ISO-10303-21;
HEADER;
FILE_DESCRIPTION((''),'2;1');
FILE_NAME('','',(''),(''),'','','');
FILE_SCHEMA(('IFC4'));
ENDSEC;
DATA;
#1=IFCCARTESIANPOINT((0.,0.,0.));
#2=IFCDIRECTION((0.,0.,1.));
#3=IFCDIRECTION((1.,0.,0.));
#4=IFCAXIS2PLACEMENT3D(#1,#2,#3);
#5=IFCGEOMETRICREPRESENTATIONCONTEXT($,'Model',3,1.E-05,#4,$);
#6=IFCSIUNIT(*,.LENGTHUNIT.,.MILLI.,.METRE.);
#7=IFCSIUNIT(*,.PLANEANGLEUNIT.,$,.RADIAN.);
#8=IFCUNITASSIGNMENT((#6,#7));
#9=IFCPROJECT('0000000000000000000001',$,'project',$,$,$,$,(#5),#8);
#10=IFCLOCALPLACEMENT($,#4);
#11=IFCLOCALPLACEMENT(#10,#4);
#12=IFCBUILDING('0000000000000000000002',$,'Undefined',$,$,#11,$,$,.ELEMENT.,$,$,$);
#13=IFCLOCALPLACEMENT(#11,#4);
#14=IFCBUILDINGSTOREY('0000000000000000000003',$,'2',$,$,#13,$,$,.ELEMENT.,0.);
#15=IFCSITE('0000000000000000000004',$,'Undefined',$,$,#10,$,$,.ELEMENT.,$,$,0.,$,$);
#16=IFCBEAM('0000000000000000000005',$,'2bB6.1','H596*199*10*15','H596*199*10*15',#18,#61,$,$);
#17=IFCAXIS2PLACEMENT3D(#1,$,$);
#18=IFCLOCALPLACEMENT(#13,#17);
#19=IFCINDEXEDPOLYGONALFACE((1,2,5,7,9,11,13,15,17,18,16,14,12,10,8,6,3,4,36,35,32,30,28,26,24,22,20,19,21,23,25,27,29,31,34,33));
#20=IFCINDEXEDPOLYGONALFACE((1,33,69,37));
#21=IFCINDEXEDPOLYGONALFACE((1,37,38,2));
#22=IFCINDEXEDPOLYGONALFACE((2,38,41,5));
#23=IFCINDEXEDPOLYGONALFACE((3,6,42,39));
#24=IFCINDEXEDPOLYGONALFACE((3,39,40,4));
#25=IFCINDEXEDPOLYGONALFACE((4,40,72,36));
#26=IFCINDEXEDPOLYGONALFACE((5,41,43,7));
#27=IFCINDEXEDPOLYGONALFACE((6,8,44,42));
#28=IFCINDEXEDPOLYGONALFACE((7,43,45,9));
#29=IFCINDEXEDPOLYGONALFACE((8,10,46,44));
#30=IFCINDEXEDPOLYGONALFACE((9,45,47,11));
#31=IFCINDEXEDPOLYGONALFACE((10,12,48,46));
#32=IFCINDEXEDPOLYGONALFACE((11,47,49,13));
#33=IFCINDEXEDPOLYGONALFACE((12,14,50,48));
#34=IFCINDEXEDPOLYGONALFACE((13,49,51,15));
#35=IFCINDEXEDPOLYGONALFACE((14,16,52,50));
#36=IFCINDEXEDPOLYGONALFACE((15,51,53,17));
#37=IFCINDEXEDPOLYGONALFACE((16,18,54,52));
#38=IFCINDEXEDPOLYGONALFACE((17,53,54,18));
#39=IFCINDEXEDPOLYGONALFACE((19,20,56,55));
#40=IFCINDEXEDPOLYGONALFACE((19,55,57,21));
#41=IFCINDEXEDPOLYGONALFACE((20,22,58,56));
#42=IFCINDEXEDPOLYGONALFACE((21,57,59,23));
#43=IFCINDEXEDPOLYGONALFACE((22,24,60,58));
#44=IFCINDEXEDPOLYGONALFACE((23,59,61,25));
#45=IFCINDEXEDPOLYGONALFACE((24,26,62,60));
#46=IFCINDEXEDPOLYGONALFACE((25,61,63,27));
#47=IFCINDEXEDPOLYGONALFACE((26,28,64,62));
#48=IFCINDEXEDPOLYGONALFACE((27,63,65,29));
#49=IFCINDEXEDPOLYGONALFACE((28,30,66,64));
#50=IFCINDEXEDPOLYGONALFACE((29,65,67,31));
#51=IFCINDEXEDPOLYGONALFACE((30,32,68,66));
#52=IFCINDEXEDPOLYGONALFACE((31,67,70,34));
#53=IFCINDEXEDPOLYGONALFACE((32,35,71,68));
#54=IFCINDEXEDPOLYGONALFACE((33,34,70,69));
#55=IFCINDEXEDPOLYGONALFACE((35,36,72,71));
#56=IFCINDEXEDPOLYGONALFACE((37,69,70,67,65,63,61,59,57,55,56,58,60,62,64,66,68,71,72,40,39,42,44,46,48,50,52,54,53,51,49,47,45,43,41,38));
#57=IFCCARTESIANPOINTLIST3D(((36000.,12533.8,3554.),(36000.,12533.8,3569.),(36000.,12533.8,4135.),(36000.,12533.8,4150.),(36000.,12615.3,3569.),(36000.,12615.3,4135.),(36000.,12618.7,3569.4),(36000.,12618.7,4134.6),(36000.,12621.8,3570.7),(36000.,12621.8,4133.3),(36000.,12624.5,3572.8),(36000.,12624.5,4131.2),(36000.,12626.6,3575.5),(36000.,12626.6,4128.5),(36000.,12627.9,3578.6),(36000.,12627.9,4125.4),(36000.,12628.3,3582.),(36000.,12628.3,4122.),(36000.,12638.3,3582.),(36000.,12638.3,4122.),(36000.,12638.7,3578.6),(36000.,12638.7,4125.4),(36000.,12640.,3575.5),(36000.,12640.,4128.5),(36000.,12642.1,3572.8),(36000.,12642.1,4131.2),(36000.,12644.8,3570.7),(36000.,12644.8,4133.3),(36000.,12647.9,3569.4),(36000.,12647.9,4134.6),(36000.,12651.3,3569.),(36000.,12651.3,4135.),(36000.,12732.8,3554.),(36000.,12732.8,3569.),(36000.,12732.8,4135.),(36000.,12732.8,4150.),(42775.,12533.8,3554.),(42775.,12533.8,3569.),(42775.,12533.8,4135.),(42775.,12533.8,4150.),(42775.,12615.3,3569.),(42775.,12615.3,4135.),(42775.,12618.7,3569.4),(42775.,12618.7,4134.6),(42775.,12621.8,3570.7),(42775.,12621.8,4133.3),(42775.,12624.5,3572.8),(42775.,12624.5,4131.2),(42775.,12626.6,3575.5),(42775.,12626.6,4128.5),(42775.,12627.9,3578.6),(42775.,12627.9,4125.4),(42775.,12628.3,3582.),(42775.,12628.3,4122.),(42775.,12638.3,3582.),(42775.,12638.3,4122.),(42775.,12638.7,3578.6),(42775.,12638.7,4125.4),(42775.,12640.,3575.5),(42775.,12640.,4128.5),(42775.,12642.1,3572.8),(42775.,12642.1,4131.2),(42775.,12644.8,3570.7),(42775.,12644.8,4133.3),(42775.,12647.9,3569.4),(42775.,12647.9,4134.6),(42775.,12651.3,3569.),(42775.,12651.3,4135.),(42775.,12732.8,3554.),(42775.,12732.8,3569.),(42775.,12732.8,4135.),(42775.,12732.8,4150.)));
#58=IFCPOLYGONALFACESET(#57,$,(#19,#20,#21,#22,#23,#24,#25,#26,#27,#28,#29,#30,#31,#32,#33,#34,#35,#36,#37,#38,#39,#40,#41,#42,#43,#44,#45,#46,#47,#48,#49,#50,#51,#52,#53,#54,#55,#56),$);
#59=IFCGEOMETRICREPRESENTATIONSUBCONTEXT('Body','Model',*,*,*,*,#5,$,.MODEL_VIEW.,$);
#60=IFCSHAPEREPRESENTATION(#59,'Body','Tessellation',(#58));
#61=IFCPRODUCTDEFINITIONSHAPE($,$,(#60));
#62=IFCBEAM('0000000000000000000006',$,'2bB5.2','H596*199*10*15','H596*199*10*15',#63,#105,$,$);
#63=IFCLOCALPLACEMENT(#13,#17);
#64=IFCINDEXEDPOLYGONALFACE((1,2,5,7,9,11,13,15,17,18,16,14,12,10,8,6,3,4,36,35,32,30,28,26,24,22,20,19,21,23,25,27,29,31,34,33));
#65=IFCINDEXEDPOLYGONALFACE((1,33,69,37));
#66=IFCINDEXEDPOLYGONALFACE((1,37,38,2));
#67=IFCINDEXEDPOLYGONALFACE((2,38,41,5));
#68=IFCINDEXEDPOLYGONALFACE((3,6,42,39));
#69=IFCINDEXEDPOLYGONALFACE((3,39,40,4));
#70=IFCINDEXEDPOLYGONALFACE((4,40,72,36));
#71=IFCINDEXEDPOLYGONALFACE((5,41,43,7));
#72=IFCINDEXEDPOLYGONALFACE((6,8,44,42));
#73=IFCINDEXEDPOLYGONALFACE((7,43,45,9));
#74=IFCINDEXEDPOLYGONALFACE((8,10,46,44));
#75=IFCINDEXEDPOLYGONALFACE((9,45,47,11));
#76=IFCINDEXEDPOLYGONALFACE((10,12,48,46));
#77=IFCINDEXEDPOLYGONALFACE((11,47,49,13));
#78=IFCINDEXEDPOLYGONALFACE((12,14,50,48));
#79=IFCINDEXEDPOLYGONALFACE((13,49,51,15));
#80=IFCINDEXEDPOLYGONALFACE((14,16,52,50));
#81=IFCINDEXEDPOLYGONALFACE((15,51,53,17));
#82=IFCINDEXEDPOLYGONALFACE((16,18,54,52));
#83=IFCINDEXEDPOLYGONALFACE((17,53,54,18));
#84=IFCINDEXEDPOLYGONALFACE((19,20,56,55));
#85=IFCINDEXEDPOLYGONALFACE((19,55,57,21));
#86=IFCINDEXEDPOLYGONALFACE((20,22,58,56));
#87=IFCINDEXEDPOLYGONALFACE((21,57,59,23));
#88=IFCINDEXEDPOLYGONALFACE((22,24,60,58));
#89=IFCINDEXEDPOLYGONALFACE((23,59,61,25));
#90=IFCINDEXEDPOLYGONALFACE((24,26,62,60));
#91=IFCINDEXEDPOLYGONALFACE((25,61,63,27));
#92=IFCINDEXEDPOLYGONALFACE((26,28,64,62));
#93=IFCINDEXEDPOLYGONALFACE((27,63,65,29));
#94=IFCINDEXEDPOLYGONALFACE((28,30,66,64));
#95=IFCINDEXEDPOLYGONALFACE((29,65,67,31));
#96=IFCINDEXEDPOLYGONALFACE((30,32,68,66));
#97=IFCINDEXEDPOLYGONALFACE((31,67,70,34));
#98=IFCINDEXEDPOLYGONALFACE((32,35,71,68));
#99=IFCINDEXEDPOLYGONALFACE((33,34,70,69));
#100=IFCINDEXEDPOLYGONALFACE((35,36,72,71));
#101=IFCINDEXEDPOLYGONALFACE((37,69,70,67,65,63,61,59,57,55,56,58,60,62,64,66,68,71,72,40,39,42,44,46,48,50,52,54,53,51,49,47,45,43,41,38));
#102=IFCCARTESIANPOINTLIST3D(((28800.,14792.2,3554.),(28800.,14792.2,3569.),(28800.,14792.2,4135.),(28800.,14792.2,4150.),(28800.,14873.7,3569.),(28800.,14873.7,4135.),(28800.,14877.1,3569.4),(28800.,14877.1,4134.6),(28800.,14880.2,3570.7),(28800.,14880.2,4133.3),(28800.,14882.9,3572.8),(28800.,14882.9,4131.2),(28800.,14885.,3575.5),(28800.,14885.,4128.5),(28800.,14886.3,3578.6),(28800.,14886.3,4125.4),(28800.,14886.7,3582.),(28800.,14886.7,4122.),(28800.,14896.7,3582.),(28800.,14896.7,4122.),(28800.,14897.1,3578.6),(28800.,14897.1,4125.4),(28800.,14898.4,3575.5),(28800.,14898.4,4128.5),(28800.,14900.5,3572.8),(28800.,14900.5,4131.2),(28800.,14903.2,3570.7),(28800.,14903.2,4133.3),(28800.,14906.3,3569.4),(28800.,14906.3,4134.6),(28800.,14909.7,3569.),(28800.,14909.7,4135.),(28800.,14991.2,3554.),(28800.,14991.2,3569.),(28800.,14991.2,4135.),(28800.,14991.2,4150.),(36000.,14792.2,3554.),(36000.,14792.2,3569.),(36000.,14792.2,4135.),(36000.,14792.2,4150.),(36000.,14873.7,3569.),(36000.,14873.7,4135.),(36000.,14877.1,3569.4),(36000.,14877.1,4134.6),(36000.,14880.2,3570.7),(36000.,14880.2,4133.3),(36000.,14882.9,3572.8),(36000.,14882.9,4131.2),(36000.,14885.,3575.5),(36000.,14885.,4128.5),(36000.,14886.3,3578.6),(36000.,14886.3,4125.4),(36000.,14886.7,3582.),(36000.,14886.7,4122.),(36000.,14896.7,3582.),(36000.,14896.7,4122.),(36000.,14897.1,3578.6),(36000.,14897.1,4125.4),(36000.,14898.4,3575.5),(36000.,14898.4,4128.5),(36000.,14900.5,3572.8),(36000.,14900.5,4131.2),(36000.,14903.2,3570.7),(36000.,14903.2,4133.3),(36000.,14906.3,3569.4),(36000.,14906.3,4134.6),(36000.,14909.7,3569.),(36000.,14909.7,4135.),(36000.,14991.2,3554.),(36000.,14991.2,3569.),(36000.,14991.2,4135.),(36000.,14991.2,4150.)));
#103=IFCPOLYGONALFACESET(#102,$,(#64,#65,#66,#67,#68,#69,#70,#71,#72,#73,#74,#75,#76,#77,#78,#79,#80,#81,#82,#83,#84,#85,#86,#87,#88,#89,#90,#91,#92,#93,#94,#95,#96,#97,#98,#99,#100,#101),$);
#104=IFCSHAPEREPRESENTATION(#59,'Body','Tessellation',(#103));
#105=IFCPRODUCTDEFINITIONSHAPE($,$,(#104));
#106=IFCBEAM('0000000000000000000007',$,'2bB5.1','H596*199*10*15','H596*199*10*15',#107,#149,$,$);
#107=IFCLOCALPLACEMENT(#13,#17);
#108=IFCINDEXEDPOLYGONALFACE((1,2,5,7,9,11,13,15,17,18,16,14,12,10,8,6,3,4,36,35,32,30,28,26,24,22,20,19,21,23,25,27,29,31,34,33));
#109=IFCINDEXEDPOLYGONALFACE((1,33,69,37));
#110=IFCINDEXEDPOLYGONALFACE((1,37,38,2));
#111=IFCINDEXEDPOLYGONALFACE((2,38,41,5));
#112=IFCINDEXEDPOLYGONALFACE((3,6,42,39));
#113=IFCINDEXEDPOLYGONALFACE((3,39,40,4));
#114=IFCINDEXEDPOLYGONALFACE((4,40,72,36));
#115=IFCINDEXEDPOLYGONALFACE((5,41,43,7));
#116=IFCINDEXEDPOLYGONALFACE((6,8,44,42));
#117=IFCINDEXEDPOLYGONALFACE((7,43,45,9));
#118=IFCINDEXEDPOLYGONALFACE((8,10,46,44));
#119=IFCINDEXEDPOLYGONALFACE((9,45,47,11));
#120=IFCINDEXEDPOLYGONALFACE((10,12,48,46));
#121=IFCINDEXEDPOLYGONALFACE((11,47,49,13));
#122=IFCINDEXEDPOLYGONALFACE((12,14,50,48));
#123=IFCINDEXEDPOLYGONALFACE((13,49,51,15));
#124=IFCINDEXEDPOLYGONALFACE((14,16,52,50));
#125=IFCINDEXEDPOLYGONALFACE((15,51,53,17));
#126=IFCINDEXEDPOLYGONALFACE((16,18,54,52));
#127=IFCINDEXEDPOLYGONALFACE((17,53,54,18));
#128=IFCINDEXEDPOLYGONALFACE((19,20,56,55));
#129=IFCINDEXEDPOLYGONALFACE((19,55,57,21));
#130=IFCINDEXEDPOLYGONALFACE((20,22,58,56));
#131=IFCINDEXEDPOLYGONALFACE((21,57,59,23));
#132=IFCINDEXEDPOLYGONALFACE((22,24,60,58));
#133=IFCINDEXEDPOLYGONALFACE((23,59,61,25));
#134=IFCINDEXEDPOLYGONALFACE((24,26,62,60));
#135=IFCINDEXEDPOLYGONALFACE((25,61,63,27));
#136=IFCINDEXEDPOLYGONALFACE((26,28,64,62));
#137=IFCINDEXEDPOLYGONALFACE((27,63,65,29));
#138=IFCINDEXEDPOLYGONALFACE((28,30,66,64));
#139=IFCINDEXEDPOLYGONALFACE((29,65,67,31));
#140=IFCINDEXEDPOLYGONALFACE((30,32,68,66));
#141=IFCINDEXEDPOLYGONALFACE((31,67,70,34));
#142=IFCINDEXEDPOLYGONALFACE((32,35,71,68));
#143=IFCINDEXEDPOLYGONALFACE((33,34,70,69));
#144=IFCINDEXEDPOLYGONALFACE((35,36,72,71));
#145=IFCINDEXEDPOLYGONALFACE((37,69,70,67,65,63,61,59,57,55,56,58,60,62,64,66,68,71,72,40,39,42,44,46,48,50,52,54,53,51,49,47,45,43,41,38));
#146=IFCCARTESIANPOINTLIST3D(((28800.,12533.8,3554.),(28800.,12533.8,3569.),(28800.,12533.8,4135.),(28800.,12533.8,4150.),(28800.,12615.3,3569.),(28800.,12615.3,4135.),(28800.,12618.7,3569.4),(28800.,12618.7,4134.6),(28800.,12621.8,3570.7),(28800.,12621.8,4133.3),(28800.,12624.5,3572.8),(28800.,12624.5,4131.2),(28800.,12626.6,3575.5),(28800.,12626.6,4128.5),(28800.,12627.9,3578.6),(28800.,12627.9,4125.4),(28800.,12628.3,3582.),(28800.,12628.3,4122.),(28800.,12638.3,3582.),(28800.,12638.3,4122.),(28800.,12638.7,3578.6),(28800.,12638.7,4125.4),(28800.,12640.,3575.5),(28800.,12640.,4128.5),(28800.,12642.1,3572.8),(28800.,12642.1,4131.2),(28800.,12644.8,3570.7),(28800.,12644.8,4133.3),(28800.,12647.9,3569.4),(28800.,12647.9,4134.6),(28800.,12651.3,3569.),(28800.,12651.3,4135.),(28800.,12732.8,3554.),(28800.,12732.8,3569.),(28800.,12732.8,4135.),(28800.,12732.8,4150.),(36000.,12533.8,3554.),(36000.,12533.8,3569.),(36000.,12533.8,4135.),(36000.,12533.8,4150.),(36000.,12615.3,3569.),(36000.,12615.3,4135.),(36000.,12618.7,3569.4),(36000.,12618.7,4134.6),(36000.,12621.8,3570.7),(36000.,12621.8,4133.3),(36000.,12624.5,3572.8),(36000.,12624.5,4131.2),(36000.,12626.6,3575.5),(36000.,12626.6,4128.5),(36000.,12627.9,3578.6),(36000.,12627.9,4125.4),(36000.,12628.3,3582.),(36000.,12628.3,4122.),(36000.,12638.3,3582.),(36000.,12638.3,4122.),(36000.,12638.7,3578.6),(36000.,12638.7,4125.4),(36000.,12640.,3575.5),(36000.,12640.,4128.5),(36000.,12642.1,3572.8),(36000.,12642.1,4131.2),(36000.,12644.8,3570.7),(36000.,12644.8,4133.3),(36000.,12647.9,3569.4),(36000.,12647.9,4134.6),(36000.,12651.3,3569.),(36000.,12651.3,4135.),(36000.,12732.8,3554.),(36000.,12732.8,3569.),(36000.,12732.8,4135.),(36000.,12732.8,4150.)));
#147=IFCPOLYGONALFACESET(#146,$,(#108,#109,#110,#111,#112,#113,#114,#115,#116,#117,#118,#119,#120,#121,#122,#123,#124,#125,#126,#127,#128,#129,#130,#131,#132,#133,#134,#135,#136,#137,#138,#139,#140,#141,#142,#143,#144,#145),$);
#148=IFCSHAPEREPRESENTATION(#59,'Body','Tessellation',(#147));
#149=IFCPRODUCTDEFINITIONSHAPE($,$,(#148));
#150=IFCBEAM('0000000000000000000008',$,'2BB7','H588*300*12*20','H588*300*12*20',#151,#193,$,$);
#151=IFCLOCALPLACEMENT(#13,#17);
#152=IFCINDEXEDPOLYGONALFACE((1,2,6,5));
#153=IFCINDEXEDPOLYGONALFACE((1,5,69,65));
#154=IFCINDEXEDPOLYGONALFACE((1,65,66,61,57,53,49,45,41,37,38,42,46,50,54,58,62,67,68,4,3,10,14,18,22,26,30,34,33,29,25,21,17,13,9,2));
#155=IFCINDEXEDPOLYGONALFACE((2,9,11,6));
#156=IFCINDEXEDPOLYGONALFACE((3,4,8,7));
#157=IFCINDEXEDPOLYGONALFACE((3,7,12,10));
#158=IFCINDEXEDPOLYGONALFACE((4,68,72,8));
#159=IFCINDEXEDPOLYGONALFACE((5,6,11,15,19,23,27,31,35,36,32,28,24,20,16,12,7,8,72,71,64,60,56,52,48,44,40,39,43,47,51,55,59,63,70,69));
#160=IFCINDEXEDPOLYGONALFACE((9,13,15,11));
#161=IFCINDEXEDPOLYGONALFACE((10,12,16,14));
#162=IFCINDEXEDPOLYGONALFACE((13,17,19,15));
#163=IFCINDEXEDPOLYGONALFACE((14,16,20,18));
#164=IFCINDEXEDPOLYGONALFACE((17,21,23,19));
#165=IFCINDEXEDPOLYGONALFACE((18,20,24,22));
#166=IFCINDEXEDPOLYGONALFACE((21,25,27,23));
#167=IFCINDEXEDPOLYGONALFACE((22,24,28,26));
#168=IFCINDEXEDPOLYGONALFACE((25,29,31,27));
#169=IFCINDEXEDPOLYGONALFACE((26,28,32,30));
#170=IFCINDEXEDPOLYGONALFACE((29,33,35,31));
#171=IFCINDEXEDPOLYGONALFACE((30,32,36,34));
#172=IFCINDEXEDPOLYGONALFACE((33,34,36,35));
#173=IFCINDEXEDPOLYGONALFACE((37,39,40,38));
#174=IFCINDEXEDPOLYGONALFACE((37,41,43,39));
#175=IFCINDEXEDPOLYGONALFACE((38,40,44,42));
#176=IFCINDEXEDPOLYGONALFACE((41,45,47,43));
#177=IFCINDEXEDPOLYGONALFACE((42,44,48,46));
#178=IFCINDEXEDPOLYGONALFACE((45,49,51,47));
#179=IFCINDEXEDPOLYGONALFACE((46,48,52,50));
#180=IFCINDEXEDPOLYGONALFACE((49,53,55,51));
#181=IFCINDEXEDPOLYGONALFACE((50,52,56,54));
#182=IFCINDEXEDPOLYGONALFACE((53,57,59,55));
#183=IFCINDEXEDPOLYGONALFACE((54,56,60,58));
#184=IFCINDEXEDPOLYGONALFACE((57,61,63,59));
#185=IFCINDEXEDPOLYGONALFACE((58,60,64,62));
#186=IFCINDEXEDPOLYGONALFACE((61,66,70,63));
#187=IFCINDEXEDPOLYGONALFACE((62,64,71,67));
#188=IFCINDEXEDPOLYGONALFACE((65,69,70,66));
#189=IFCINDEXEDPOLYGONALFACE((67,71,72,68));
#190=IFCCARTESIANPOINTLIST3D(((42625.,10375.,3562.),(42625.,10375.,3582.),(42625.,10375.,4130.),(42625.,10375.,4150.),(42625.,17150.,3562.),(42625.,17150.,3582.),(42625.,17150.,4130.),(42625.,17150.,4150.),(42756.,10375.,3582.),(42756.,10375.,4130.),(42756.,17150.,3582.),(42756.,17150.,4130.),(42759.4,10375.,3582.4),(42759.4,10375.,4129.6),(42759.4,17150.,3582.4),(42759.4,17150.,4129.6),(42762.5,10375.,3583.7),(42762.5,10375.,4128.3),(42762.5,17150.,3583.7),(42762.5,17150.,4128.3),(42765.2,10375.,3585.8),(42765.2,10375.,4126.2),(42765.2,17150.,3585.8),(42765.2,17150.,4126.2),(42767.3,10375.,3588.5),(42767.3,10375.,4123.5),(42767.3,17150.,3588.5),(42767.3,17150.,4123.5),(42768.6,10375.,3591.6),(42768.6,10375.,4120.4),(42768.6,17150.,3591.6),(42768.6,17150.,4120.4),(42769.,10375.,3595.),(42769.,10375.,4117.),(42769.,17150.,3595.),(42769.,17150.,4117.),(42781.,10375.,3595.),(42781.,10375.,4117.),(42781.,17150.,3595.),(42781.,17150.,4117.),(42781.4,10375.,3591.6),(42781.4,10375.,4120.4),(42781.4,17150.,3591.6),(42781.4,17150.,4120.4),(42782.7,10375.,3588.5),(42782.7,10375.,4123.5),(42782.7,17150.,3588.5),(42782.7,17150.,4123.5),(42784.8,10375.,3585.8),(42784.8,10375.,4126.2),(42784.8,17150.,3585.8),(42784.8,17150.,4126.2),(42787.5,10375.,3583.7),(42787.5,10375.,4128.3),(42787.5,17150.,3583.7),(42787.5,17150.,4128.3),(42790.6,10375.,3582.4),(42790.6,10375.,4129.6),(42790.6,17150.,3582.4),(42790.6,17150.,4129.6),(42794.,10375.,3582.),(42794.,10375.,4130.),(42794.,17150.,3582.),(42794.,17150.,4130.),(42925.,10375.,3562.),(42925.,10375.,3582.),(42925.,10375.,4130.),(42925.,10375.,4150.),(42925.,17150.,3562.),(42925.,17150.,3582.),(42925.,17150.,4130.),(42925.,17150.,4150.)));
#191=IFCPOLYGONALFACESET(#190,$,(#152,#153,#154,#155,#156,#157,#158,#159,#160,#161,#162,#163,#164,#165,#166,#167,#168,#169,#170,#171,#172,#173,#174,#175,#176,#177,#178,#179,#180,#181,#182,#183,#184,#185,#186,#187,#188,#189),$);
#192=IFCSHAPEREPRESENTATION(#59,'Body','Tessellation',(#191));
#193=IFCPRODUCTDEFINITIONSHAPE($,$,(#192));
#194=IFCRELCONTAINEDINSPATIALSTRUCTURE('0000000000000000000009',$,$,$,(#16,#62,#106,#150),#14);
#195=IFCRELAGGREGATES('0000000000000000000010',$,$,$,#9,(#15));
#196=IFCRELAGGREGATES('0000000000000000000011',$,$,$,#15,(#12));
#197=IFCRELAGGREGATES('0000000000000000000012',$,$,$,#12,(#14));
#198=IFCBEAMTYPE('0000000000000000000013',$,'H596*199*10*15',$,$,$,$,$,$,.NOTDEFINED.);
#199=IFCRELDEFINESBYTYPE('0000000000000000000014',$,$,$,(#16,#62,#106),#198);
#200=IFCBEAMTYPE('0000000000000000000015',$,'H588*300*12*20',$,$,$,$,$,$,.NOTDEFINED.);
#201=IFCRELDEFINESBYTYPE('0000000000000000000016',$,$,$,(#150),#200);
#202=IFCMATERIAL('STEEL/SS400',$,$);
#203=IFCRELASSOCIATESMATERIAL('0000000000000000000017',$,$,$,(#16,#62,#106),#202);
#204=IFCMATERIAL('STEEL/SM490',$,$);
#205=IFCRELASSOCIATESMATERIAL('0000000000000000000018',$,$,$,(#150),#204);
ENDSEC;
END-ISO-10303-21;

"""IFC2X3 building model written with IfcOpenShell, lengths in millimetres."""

from ifc_helpers import new_model, si_unit, frame, origin_with_axes, origin_2d_with_axis, place, context, subcontext, project, spatial, i_section, extrude, material, type_object, element, save


model = new_model("IFC2X3")

# Units and contexts
model_context = context("Model", 3, precision=1e-05, world=origin_with_axes())
body_context = subcontext(model_context, "Body", "Model", "MODEL_VIEW")
ifc_project = project(units=[si_unit("LENGTHUNIT", "METRE", prefix="MILLI"), si_unit("PLANEANGLEUNIT", "RADIAN")], contexts=[model_context])

# Site, building, storey
site_placement = place(None, origin_with_axes())
site = spatial("IfcSite", under=ifc_project, at=site_placement, Name="Undefined", CompositionType="ELEMENT", RefElevation=0.0)
building_placement = place(site_placement, origin_with_axes())
building = spatial("IfcBuilding", under=site, at=building_placement, Name="Undefined", CompositionType="ELEMENT")
storey_placement = place(building_placement, origin_with_axes())
storey = spatial("IfcBuildingStorey", under=building, at=storey_placement, Name="2", CompositionType="ELEMENT", Elevation=0.0)

# Beams
ifc_material_1 = material(Name="STEEL/SS400")
beam_type_1 = type_object("IfcBeamType", Name="H596*199*10*15", PredefinedType="NOTDEFINED")
for number, where, z_axis, x_axis, name in (
    (1, (36000.0, 12633.3, 3852.0), (0.0, 0.0, 1.0), (1.0, 0.0, 0.0), "2bB6.1"),
):
    element("IfcBeam", number, at=place(storey_placement, frame(where, z_axis=z_axis, x_axis=x_axis)), inside=storey, type_object=beam_type_1, material=ifc_material_1, Name=name, Description="H596*199*10*15", ObjectType="H596*199*10*15", context=body_context, shape_type="SweptSolid", body=[
        extrude(i_section(OverallWidth=199.0, OverallDepth=596.0, WebThickness=10.0, FlangeThickness=15.0, FilletRadius=13.0, at=origin_2d_with_axis()), frame((6775.0, 0.0, 0.0), z_axis=(-1.0, 0.0, 0.0), x_axis=(0.0, -1.0, 0.0)), (0.0, 0.0, 1.0), 6775.0),
    ])
for number, where, z_axis, x_axis, name in (
    (2, (28800.0, 14891.7, 3852.0), (0.0, 0.0, 1.0), (1.0, 0.0, 0.0), "2bB5.2"),
    (3, (28800.0, 12633.3, 3852.0), (0.0, 0.0, 1.0), (1.0, 0.0, 0.0), "2bB5.1"),
):
    element("IfcBeam", number, at=place(storey_placement, frame(where, z_axis=z_axis, x_axis=x_axis)), inside=storey, type_object=beam_type_1, material=ifc_material_1, Name=name, Description="H596*199*10*15", ObjectType="H596*199*10*15", context=body_context, shape_type="SweptSolid", body=[
        extrude(i_section(OverallWidth=199.0, OverallDepth=596.0, WebThickness=10.0, FlangeThickness=15.0, FilletRadius=13.0, at=origin_2d_with_axis()), frame((7200.0, 0.0, 0.0), z_axis=(-1.0, 0.0, 0.0), x_axis=(0.0, -1.0, 0.0)), (0.0, 0.0, 1.0), 7200.0),
    ])
ifc_material_2 = material(Name="STEEL/SM490")
beam_type_2 = type_object("IfcBeamType", Name="H588*300*12*20", PredefinedType="NOTDEFINED")
for number, where, z_axis, x_axis, name in (
    (4, (42775.0, 10375.0, 3856.0), (0.0, 0.0, 1.0), (0.0, 1.0, 0.0), "2BB7"),
):
    element("IfcBeam", number, at=place(storey_placement, frame(where, z_axis=z_axis, x_axis=x_axis)), inside=storey, type_object=beam_type_2, material=ifc_material_2, Name=name, Description="H588*300*12*20", ObjectType="H588*300*12*20", context=body_context, shape_type="SweptSolid", body=[
        extrude(i_section(OverallWidth=300.0, OverallDepth=588.0, WebThickness=12.0, FlangeThickness=20.0, FilletRadius=13.0, at=origin_2d_with_axis()), frame((6775.0, 0.0, 0.0), z_axis=(-1.0, 0.0, 0.0), x_axis=(0.0, -1.0, 0.0)), (0.0, 0.0, 1.0), 6775.0),
    ])

save(model, "model.ifc")
